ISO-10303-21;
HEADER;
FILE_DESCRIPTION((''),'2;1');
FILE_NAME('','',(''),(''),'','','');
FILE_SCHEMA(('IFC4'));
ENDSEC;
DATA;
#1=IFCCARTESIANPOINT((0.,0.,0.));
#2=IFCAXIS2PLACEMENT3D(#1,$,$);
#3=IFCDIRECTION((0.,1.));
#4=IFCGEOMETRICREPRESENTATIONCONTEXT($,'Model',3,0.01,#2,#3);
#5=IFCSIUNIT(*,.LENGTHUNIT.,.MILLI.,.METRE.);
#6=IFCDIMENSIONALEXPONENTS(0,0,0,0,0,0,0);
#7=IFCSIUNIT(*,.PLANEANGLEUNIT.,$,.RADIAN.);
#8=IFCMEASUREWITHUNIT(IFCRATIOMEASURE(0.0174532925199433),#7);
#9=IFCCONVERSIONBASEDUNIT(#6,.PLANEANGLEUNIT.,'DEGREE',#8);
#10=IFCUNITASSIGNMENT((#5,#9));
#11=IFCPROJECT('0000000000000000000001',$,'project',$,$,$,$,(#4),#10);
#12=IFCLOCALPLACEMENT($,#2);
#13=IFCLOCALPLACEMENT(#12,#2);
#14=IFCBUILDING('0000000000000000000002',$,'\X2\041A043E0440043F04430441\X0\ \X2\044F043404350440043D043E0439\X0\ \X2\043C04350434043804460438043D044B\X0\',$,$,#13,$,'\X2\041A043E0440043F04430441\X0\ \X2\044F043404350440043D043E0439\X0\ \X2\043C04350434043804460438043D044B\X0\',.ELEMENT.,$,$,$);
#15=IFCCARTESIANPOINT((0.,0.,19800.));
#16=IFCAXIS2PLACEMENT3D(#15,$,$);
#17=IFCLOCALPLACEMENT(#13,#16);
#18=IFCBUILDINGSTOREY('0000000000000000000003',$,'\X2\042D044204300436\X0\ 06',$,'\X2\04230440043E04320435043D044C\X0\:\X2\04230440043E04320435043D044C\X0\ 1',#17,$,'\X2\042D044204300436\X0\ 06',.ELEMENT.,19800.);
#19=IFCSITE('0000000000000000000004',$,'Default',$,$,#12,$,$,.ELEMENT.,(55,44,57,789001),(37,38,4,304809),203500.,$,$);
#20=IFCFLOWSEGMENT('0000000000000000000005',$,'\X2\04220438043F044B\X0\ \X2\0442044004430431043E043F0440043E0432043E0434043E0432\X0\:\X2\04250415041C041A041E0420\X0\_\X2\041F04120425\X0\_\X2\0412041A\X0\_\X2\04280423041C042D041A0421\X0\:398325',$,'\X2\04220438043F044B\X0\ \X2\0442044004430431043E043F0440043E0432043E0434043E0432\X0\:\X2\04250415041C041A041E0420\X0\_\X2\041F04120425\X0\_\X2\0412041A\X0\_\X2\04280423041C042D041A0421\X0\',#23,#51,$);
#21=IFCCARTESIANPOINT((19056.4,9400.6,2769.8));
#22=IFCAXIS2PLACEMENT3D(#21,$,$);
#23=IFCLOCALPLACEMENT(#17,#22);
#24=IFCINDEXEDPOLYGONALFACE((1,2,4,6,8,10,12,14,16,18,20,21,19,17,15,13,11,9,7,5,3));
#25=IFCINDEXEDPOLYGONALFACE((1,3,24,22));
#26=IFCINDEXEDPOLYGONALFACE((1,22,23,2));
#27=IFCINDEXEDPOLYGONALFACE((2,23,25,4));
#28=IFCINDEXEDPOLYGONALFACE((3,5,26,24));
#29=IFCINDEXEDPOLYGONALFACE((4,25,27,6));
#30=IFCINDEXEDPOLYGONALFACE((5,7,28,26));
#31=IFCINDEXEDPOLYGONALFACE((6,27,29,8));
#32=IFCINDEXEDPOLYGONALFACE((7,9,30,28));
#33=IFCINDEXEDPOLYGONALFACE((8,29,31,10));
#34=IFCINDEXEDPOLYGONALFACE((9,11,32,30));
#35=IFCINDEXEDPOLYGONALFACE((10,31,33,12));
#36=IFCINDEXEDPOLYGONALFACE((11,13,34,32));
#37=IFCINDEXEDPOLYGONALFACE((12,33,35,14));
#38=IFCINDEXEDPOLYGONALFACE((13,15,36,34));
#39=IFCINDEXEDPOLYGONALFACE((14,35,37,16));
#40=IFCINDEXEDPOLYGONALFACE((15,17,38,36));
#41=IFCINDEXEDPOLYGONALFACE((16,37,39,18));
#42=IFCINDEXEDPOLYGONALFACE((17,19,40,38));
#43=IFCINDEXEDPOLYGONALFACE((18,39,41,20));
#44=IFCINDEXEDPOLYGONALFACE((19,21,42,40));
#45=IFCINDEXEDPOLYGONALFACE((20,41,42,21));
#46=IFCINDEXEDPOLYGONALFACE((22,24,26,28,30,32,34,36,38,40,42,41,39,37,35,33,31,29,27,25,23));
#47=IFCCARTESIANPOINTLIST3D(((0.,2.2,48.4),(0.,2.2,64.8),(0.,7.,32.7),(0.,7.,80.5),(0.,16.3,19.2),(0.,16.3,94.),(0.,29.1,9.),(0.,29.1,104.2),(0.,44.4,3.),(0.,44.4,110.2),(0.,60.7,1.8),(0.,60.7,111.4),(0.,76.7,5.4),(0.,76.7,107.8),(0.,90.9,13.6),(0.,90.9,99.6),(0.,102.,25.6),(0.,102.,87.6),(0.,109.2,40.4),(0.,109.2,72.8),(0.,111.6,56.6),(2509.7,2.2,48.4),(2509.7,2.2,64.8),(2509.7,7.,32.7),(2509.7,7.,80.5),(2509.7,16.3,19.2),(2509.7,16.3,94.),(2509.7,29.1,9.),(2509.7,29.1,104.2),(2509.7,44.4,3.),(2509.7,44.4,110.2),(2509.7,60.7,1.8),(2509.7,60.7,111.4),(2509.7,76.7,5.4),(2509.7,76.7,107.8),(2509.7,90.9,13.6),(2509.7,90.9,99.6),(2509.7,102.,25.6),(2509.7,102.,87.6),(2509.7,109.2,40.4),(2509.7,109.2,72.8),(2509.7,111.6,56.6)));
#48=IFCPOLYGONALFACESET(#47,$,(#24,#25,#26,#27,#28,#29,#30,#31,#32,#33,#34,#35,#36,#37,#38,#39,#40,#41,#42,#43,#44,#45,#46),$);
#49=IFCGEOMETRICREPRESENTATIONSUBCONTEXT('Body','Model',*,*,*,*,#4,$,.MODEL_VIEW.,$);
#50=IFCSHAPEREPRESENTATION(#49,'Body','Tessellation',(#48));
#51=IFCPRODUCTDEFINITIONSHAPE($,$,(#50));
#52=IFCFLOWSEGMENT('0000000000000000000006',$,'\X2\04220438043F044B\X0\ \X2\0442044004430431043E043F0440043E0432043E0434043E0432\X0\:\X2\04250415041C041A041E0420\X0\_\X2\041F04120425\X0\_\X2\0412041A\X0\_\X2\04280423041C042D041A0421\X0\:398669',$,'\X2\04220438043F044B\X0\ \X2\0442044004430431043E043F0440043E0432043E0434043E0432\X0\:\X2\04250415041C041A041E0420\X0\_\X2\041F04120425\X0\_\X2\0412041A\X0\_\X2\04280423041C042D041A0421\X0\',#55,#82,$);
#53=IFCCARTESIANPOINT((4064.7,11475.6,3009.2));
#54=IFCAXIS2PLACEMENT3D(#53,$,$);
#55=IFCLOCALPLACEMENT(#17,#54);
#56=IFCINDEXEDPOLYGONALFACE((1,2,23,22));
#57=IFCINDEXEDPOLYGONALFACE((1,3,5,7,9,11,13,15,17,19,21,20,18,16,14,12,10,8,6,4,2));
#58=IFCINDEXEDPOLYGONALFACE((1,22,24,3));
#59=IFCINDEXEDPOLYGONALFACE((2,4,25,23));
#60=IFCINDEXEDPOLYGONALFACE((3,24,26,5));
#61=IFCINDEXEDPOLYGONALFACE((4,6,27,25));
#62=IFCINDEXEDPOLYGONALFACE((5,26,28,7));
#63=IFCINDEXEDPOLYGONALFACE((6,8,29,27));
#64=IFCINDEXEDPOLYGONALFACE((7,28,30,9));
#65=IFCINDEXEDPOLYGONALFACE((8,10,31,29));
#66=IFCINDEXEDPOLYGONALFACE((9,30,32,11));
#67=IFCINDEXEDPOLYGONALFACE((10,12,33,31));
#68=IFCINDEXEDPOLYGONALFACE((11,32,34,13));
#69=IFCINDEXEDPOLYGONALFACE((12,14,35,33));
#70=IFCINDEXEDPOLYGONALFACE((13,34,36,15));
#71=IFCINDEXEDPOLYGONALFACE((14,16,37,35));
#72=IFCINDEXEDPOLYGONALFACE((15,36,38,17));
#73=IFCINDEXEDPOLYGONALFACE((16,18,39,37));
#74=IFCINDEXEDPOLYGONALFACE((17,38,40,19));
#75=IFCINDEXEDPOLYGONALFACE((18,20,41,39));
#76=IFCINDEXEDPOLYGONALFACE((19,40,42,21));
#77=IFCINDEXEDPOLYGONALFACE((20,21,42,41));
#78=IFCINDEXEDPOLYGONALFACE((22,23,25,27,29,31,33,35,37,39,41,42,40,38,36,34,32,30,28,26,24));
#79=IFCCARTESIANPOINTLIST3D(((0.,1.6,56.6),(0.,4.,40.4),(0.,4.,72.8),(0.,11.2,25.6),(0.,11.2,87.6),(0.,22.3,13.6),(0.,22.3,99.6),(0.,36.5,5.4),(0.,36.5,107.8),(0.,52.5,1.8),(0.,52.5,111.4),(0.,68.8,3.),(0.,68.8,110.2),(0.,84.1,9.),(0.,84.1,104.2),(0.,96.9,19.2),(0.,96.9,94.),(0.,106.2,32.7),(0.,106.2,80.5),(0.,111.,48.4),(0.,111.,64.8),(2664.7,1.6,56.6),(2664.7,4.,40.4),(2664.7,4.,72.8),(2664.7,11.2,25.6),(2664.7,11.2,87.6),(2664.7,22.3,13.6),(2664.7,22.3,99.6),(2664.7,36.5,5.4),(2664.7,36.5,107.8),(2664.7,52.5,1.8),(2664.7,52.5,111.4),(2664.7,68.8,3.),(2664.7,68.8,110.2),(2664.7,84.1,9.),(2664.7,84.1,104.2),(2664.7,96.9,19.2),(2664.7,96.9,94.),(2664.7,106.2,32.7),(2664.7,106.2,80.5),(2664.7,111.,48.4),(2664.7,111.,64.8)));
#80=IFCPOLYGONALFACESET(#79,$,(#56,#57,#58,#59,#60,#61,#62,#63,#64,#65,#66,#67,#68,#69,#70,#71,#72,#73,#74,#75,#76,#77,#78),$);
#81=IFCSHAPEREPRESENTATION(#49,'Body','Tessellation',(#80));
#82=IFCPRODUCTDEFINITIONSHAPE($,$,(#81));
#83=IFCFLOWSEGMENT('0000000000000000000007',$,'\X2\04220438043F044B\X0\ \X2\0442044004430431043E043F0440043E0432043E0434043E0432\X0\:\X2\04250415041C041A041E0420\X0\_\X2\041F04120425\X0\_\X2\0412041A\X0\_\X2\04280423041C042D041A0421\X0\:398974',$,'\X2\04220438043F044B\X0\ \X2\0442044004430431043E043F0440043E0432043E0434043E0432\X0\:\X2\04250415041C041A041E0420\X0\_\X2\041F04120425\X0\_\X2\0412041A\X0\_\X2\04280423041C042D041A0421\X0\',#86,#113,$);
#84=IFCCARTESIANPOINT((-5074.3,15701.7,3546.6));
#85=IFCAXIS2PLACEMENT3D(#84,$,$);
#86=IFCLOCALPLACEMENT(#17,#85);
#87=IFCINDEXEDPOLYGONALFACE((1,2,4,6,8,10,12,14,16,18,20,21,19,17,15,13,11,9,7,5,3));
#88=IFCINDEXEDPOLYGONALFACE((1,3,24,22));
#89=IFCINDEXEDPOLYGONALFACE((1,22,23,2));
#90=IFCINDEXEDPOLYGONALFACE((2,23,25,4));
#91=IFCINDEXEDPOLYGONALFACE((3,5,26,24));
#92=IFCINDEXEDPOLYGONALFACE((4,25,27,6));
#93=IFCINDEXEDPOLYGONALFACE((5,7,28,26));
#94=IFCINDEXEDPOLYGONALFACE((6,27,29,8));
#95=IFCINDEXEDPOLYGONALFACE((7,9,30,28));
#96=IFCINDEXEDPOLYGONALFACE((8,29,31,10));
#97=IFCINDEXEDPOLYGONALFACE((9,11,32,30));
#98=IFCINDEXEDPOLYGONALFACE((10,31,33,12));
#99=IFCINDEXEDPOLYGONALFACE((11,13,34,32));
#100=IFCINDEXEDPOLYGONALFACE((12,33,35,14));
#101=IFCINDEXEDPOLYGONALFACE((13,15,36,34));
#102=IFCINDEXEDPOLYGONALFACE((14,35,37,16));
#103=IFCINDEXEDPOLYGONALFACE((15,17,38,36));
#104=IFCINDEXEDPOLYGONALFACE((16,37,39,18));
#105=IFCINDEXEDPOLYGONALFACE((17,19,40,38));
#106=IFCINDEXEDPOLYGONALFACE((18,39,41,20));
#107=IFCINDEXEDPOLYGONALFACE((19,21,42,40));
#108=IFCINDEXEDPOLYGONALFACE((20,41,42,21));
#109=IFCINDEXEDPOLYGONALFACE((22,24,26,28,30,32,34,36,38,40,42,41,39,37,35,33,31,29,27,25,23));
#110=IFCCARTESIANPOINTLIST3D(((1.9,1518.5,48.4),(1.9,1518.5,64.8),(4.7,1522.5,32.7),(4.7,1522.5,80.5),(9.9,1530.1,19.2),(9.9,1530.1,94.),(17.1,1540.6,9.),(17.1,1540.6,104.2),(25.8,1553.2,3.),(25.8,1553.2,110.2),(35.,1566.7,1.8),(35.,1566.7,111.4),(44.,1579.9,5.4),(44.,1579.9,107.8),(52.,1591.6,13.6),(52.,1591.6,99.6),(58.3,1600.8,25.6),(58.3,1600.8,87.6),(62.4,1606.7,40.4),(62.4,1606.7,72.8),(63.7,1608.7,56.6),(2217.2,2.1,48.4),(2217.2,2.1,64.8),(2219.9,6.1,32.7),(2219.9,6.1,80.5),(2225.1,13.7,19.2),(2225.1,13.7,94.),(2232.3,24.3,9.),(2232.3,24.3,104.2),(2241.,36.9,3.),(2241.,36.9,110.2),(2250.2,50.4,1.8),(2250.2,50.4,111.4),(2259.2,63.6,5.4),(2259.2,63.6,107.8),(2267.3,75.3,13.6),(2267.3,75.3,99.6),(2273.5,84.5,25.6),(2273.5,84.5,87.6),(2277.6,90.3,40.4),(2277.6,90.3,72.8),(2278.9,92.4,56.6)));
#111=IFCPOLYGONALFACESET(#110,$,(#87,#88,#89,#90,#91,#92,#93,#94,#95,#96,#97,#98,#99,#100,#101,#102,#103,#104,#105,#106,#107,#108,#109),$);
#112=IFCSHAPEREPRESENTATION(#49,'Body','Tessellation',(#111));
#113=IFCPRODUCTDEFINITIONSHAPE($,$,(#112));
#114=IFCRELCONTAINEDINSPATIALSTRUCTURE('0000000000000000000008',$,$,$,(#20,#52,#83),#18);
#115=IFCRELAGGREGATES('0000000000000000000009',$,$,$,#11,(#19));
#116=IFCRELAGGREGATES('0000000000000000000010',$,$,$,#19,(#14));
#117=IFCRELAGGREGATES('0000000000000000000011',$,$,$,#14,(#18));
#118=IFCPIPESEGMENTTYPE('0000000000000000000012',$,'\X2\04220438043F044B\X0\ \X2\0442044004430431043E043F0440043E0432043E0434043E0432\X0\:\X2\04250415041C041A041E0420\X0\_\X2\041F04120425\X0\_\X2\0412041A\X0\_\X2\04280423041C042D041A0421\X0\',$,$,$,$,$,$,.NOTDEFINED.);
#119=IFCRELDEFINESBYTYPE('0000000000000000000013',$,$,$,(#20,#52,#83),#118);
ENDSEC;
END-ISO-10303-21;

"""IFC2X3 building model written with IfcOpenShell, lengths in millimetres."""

from ifc_helpers import new_model, entity, si_unit, converted_unit, direction, frame, origin, origin_2d_with_axis, place, context, subcontext, project, spatial, circle, extrude, type_object, element, save


model = new_model("IFC2X3")

# Units and contexts
model_context = context("Model", 3, precision=0.01, world=origin(), true_north=direction((0.0, 1.0)))
body_context = subcontext(model_context, "Body", "Model", "MODEL_VIEW")
ifc_project = project(units=[si_unit("LENGTHUNIT", "METRE", prefix="MILLI"), converted_unit("PLANEANGLEUNIT", "DEGREE", entity("IfcRatioMeasure", 0.0174532925199433), si_unit("PLANEANGLEUNIT", "RADIAN"), dimensions=[0, 0, 0, 0, 0, 0, 0])], contexts=[model_context])

# Site, building, storey
site_placement = place(None, origin())
site = spatial("IfcSite", under=ifc_project, at=site_placement, Name="Default", CompositionType="ELEMENT", RefLatitude=(55, 44, 57, 789001), RefLongitude=(37, 38, 4, 304809), RefElevation=203500.0)
building_placement = place(site_placement, origin())
building = spatial("IfcBuilding", under=site, at=building_placement, Name="Корпус ядерной медицины", LongName="Корпус ядерной медицины", CompositionType="ELEMENT")
storey_placement = place(building_placement, frame((0.0, 0.0, 19800.0)))
storey = spatial("IfcBuildingStorey", under=building, at=storey_placement, Name="Этаж 06", ObjectType="Уровень:Уровень 1", LongName="Этаж 06", CompositionType="ELEMENT", Elevation=19800.0)

# Flow segments
pipe_segment_type = type_object("IfcPipeSegmentType", Name="Типы трубопроводов:ХЕМКОР_ПВХ_ВК_ШУМЭКС", PredefinedType="NOTDEFINED")
flow_segment_1_placement = place(storey_placement, frame((19056.4, 9400.6, 2769.8)))
element("IfcFlowSegment", 1, at=flow_segment_1_placement, inside=storey, type_object=pipe_segment_type, Name="Типы трубопроводов:ХЕМКОР_ПВХ_ВК_ШУМЭКС:398325", ObjectType="Типы трубопроводов:ХЕМКОР_ПВХ_ВК_ШУМЭКС", context=body_context, shape_type="SweptSolid", body=[
    extrude(circle(Radius=55.0, at=origin_2d_with_axis()), frame((0.0, 56.6, 56.6), z_axis=(1.0, 0.0, 0.0), x_axis=(0.0, 1.0, 0.0)), (0.0, 0.0, 1.0), 2509.7),
])
flow_segment_2_placement = place(storey_placement, frame((4064.7, 11475.6, 3009.2)))
element("IfcFlowSegment", 2, at=flow_segment_2_placement, inside=storey, type_object=pipe_segment_type, Name="Типы трубопроводов:ХЕМКОР_ПВХ_ВК_ШУМЭКС:398669", ObjectType="Типы трубопроводов:ХЕМКОР_ПВХ_ВК_ШУМЭКС", context=body_context, shape_type="SweptSolid", body=[
    extrude(circle(Radius=55.0, at=origin_2d_with_axis()), frame((0.0, 56.6, 56.6), z_axis=(1.0, 0.0, 0.0), x_axis=(0.0, -1.0, 0.0)), (0.0, 0.0, 1.0), 2664.7),
])
flow_segment_3_placement = place(storey_placement, frame((-5074.3, 15701.7, 3546.6)))
element("IfcFlowSegment", 3, at=flow_segment_3_placement, inside=storey, type_object=pipe_segment_type, Name="Типы трубопроводов:ХЕМКОР_ПВХ_ВК_ШУМЭКС:398974", ObjectType="Типы трубопроводов:ХЕМКОР_ПВХ_ВК_ШУМЭКС", context=body_context, shape_type="SweptSolid", body=[
    extrude(circle(Radius=55.0, at=origin_2d_with_axis()), frame((2247.9, 47.0, 56.6), z_axis=(-0.825187, 0.564859, 0.0), x_axis=(0.564859, 0.825187, 0.0)), (0.0, 0.0, 1.0), 2684.5),
])

save(model, "model.ifc")
